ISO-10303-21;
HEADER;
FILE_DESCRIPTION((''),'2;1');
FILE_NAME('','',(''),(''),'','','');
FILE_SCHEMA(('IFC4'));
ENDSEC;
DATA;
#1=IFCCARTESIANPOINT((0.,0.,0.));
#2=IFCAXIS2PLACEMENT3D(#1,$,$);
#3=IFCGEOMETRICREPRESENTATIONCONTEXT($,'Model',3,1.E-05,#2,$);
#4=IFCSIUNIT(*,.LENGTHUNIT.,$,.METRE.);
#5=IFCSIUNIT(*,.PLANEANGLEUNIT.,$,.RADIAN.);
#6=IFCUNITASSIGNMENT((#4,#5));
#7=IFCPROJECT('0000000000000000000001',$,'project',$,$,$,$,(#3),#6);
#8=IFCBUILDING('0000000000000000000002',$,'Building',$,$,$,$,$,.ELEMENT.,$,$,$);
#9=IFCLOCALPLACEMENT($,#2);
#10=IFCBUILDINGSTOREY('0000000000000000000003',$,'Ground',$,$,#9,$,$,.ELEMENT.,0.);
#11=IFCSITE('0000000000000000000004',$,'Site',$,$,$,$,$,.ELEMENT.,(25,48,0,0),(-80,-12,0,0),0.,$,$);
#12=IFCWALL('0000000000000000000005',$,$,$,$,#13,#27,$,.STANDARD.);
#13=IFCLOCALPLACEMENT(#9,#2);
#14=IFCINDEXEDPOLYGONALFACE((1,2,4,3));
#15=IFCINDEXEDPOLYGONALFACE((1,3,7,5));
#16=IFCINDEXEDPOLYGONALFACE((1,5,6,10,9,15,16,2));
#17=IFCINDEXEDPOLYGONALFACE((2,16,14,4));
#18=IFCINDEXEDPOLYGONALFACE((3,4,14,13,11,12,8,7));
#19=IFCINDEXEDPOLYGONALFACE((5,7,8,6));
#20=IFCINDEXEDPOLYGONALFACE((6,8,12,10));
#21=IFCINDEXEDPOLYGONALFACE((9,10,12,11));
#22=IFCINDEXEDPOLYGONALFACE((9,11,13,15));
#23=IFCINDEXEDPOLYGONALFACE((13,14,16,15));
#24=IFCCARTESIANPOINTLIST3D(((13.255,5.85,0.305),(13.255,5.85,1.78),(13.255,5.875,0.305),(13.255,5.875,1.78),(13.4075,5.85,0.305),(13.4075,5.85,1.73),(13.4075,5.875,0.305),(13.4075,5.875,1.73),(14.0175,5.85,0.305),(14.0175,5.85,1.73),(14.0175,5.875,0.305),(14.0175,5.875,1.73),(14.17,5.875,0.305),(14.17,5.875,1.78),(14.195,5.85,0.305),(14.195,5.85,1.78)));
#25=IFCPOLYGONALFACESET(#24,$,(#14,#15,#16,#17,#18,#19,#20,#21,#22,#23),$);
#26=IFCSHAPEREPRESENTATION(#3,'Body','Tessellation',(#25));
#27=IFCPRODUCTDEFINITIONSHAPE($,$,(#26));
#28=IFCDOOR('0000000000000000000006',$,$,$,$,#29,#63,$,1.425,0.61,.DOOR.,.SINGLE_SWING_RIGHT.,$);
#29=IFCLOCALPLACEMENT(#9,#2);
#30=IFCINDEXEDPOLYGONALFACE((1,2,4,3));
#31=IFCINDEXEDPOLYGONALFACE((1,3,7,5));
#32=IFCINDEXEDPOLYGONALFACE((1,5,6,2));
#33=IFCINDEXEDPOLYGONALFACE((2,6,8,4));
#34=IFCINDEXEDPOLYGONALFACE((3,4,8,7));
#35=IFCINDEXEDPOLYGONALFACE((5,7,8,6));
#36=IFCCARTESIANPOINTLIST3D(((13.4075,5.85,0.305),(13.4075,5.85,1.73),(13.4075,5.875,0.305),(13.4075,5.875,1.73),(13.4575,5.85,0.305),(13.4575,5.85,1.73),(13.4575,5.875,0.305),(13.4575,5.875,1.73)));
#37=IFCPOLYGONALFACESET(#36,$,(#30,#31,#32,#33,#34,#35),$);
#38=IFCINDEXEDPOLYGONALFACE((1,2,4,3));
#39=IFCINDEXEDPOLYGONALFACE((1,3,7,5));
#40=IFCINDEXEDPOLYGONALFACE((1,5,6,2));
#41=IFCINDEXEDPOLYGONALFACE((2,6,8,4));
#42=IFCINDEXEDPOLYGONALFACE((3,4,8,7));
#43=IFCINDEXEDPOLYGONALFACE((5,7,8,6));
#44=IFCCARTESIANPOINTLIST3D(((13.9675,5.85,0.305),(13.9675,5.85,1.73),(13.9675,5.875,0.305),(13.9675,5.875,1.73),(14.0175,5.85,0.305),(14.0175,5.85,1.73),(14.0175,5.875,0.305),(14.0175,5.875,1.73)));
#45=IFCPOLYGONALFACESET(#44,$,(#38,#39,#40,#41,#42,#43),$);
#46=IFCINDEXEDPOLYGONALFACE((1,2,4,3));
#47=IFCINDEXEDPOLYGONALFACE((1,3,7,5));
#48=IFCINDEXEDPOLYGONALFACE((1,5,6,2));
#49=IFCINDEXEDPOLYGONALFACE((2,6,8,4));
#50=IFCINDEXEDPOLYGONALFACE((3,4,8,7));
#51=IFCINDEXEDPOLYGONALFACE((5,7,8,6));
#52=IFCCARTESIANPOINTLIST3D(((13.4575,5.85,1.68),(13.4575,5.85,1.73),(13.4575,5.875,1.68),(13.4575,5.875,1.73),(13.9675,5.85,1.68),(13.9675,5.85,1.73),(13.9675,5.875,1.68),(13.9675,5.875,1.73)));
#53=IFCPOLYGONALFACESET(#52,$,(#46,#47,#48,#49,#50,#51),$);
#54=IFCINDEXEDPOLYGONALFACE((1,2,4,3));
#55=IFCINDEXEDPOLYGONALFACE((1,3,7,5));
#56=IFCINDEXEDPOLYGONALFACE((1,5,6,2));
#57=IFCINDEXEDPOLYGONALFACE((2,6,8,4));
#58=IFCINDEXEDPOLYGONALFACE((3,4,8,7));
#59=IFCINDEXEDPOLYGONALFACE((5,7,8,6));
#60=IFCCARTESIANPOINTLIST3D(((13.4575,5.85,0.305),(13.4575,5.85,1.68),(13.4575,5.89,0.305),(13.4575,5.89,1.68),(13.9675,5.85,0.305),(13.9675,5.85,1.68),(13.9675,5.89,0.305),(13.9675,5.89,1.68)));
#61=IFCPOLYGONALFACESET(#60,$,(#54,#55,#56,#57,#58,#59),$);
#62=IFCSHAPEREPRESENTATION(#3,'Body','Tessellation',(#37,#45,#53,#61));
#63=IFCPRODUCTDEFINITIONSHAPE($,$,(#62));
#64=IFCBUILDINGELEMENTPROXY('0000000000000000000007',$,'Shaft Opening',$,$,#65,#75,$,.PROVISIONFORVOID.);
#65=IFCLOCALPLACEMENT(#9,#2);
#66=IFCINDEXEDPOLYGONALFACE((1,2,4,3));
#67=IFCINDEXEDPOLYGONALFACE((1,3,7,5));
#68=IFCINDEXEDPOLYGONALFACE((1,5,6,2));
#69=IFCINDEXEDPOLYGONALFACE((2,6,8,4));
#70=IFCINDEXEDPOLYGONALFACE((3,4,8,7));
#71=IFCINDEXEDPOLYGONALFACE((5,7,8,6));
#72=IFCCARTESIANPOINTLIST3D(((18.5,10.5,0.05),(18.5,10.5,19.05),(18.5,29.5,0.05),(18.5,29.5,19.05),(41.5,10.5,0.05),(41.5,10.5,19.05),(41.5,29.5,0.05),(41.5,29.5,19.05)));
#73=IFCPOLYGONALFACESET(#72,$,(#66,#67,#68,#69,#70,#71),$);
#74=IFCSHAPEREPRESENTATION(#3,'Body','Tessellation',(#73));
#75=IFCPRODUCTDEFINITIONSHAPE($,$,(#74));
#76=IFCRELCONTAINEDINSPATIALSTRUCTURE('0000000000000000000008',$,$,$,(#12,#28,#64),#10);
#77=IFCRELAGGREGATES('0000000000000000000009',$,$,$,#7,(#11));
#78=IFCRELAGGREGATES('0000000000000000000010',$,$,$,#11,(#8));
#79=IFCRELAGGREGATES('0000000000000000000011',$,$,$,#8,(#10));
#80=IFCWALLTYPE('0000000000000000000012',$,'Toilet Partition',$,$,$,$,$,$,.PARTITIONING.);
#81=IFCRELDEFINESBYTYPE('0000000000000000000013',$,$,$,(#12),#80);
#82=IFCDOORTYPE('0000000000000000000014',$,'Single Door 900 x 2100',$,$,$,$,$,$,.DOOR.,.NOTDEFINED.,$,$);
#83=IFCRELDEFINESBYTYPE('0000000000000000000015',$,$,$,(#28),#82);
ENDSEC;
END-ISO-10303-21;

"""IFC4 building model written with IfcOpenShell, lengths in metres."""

from ifc_helpers import new_model, si_unit, frame, frame_2d, origin, origin_with_axes, origin_2d, place, context, project, spatial, polyline, rectangle, outline, extrude, type_object, element, fill, save


model = new_model("IFC4")

# Units and contexts
model_context = context("Model", 3, precision=1e-05, world=origin())
ifc_project = project(units=[si_unit("LENGTHUNIT", "METRE"), si_unit("PLANEANGLEUNIT", "RADIAN")], contexts=[model_context])

# Site, building, storey
site = spatial("IfcSite", under=ifc_project, Name="Site", CompositionType="ELEMENT", RefLatitude=(25, 48, 0, 0), RefLongitude=(-80, -12, 0, 0), RefElevation=0.0)
building = spatial("IfcBuilding", under=site, Name="Building", CompositionType="ELEMENT")
storey_placement = place(None, origin())
storey = spatial("IfcBuildingStorey", under=building, at=storey_placement, Name="Ground", CompositionType="ELEMENT", Elevation=0.0)

# Shared definitions
door_type = type_object("IfcDoorType", Name="Single Door 900 x 2100", OperationType="NOTDEFINED", PredefinedType="DOOR")

# Wall, opening, door
wall_type_1 = type_object("IfcWallType", Name="Toilet Partition", PredefinedType="PARTITIONING")
wall_1_placement = place(None, frame((13.255, 5.8625, 0.305), z_axis=(0.0, 0.0, 1.0), x_axis=(1.0, 0.0, 0.0)))
wall_1 = element("IfcWall", 1, at=wall_1_placement, inside=storey, type_object=wall_type_1, PredefinedType="STANDARD", context=model_context, shape_type="SweptSolid", body=[
    extrude(outline(polyline([(0.0, -0.0125), (0.94, -0.0125), (0.915, 0.0125), (0.0, 0.0125), (0.0, -0.0125)])), origin(), (0.0, 0.0, 1.0), 1.475),
])
opening_1_placement = place(wall_1_placement, frame((0.4575, 0.0, 0.0), z_axis=(0.0, 0.0, 1.0), x_axis=(1.0, 0.0, 0.0)))
opening_1 = element("IfcOpeningElement", 2, at=opening_1_placement, cuts=wall_1, PredefinedType="OPENING", context=model_context, shape_type="SweptSolid", body=[
    extrude(rectangle(XDim=0.61, YDim=0.027, at=origin_2d()), origin(), (0.0, 0.0, 1.0), 1.425),
])
door_1_placement = place(opening_1_placement, origin_with_axes())
door_1 = element("IfcDoor", 3, at=door_1_placement, inside=storey, type_object=door_type, OperationType="SINGLE_SWING_RIGHT", OverallHeight=1.425, OverallWidth=0.61, PredefinedType="DOOR", context=model_context, shape_type="SweptSolid", body=[
    extrude(rectangle(XDim=0.05, YDim=0.025, at=frame_2d((-0.28, 0.0))), origin(), (0.0, 0.0, 1.0), 1.425),
    extrude(rectangle(XDim=0.05, YDim=0.025, at=frame_2d((0.28, 0.0))), origin(), (0.0, 0.0, 1.0), 1.425),
    extrude(rectangle(XDim=0.51, YDim=0.025, at=origin_2d()), frame((0.0, 0.0, 1.375)), (0.0, 0.0, 1.0), 0.05),
    extrude(rectangle(XDim=0.51, YDim=0.04, at=frame_2d((0.0, 0.0075))), origin(), (0.0, 0.0, 1.0), 1.375),
])
fill(opening_1, door_1)

# Building element proxy
proxy_placement = place(None, frame((0.0, 0.0, 19.05)))
element("IfcBuildingElementProxy", 4, at=proxy_placement, inside=storey, Name="Shaft Opening", PredefinedType="PROVISIONFORVOID", context=model_context, shape_type="SweptSolid", body=[
    extrude(outline(polyline([(18.5, 10.5), (41.5, 10.5), (41.5, 29.5), (18.5, 29.5), (18.5, 10.5)])), origin(), (0.0, 0.0, -1.0), 19.0),
])

save(model, "model.ifc")
